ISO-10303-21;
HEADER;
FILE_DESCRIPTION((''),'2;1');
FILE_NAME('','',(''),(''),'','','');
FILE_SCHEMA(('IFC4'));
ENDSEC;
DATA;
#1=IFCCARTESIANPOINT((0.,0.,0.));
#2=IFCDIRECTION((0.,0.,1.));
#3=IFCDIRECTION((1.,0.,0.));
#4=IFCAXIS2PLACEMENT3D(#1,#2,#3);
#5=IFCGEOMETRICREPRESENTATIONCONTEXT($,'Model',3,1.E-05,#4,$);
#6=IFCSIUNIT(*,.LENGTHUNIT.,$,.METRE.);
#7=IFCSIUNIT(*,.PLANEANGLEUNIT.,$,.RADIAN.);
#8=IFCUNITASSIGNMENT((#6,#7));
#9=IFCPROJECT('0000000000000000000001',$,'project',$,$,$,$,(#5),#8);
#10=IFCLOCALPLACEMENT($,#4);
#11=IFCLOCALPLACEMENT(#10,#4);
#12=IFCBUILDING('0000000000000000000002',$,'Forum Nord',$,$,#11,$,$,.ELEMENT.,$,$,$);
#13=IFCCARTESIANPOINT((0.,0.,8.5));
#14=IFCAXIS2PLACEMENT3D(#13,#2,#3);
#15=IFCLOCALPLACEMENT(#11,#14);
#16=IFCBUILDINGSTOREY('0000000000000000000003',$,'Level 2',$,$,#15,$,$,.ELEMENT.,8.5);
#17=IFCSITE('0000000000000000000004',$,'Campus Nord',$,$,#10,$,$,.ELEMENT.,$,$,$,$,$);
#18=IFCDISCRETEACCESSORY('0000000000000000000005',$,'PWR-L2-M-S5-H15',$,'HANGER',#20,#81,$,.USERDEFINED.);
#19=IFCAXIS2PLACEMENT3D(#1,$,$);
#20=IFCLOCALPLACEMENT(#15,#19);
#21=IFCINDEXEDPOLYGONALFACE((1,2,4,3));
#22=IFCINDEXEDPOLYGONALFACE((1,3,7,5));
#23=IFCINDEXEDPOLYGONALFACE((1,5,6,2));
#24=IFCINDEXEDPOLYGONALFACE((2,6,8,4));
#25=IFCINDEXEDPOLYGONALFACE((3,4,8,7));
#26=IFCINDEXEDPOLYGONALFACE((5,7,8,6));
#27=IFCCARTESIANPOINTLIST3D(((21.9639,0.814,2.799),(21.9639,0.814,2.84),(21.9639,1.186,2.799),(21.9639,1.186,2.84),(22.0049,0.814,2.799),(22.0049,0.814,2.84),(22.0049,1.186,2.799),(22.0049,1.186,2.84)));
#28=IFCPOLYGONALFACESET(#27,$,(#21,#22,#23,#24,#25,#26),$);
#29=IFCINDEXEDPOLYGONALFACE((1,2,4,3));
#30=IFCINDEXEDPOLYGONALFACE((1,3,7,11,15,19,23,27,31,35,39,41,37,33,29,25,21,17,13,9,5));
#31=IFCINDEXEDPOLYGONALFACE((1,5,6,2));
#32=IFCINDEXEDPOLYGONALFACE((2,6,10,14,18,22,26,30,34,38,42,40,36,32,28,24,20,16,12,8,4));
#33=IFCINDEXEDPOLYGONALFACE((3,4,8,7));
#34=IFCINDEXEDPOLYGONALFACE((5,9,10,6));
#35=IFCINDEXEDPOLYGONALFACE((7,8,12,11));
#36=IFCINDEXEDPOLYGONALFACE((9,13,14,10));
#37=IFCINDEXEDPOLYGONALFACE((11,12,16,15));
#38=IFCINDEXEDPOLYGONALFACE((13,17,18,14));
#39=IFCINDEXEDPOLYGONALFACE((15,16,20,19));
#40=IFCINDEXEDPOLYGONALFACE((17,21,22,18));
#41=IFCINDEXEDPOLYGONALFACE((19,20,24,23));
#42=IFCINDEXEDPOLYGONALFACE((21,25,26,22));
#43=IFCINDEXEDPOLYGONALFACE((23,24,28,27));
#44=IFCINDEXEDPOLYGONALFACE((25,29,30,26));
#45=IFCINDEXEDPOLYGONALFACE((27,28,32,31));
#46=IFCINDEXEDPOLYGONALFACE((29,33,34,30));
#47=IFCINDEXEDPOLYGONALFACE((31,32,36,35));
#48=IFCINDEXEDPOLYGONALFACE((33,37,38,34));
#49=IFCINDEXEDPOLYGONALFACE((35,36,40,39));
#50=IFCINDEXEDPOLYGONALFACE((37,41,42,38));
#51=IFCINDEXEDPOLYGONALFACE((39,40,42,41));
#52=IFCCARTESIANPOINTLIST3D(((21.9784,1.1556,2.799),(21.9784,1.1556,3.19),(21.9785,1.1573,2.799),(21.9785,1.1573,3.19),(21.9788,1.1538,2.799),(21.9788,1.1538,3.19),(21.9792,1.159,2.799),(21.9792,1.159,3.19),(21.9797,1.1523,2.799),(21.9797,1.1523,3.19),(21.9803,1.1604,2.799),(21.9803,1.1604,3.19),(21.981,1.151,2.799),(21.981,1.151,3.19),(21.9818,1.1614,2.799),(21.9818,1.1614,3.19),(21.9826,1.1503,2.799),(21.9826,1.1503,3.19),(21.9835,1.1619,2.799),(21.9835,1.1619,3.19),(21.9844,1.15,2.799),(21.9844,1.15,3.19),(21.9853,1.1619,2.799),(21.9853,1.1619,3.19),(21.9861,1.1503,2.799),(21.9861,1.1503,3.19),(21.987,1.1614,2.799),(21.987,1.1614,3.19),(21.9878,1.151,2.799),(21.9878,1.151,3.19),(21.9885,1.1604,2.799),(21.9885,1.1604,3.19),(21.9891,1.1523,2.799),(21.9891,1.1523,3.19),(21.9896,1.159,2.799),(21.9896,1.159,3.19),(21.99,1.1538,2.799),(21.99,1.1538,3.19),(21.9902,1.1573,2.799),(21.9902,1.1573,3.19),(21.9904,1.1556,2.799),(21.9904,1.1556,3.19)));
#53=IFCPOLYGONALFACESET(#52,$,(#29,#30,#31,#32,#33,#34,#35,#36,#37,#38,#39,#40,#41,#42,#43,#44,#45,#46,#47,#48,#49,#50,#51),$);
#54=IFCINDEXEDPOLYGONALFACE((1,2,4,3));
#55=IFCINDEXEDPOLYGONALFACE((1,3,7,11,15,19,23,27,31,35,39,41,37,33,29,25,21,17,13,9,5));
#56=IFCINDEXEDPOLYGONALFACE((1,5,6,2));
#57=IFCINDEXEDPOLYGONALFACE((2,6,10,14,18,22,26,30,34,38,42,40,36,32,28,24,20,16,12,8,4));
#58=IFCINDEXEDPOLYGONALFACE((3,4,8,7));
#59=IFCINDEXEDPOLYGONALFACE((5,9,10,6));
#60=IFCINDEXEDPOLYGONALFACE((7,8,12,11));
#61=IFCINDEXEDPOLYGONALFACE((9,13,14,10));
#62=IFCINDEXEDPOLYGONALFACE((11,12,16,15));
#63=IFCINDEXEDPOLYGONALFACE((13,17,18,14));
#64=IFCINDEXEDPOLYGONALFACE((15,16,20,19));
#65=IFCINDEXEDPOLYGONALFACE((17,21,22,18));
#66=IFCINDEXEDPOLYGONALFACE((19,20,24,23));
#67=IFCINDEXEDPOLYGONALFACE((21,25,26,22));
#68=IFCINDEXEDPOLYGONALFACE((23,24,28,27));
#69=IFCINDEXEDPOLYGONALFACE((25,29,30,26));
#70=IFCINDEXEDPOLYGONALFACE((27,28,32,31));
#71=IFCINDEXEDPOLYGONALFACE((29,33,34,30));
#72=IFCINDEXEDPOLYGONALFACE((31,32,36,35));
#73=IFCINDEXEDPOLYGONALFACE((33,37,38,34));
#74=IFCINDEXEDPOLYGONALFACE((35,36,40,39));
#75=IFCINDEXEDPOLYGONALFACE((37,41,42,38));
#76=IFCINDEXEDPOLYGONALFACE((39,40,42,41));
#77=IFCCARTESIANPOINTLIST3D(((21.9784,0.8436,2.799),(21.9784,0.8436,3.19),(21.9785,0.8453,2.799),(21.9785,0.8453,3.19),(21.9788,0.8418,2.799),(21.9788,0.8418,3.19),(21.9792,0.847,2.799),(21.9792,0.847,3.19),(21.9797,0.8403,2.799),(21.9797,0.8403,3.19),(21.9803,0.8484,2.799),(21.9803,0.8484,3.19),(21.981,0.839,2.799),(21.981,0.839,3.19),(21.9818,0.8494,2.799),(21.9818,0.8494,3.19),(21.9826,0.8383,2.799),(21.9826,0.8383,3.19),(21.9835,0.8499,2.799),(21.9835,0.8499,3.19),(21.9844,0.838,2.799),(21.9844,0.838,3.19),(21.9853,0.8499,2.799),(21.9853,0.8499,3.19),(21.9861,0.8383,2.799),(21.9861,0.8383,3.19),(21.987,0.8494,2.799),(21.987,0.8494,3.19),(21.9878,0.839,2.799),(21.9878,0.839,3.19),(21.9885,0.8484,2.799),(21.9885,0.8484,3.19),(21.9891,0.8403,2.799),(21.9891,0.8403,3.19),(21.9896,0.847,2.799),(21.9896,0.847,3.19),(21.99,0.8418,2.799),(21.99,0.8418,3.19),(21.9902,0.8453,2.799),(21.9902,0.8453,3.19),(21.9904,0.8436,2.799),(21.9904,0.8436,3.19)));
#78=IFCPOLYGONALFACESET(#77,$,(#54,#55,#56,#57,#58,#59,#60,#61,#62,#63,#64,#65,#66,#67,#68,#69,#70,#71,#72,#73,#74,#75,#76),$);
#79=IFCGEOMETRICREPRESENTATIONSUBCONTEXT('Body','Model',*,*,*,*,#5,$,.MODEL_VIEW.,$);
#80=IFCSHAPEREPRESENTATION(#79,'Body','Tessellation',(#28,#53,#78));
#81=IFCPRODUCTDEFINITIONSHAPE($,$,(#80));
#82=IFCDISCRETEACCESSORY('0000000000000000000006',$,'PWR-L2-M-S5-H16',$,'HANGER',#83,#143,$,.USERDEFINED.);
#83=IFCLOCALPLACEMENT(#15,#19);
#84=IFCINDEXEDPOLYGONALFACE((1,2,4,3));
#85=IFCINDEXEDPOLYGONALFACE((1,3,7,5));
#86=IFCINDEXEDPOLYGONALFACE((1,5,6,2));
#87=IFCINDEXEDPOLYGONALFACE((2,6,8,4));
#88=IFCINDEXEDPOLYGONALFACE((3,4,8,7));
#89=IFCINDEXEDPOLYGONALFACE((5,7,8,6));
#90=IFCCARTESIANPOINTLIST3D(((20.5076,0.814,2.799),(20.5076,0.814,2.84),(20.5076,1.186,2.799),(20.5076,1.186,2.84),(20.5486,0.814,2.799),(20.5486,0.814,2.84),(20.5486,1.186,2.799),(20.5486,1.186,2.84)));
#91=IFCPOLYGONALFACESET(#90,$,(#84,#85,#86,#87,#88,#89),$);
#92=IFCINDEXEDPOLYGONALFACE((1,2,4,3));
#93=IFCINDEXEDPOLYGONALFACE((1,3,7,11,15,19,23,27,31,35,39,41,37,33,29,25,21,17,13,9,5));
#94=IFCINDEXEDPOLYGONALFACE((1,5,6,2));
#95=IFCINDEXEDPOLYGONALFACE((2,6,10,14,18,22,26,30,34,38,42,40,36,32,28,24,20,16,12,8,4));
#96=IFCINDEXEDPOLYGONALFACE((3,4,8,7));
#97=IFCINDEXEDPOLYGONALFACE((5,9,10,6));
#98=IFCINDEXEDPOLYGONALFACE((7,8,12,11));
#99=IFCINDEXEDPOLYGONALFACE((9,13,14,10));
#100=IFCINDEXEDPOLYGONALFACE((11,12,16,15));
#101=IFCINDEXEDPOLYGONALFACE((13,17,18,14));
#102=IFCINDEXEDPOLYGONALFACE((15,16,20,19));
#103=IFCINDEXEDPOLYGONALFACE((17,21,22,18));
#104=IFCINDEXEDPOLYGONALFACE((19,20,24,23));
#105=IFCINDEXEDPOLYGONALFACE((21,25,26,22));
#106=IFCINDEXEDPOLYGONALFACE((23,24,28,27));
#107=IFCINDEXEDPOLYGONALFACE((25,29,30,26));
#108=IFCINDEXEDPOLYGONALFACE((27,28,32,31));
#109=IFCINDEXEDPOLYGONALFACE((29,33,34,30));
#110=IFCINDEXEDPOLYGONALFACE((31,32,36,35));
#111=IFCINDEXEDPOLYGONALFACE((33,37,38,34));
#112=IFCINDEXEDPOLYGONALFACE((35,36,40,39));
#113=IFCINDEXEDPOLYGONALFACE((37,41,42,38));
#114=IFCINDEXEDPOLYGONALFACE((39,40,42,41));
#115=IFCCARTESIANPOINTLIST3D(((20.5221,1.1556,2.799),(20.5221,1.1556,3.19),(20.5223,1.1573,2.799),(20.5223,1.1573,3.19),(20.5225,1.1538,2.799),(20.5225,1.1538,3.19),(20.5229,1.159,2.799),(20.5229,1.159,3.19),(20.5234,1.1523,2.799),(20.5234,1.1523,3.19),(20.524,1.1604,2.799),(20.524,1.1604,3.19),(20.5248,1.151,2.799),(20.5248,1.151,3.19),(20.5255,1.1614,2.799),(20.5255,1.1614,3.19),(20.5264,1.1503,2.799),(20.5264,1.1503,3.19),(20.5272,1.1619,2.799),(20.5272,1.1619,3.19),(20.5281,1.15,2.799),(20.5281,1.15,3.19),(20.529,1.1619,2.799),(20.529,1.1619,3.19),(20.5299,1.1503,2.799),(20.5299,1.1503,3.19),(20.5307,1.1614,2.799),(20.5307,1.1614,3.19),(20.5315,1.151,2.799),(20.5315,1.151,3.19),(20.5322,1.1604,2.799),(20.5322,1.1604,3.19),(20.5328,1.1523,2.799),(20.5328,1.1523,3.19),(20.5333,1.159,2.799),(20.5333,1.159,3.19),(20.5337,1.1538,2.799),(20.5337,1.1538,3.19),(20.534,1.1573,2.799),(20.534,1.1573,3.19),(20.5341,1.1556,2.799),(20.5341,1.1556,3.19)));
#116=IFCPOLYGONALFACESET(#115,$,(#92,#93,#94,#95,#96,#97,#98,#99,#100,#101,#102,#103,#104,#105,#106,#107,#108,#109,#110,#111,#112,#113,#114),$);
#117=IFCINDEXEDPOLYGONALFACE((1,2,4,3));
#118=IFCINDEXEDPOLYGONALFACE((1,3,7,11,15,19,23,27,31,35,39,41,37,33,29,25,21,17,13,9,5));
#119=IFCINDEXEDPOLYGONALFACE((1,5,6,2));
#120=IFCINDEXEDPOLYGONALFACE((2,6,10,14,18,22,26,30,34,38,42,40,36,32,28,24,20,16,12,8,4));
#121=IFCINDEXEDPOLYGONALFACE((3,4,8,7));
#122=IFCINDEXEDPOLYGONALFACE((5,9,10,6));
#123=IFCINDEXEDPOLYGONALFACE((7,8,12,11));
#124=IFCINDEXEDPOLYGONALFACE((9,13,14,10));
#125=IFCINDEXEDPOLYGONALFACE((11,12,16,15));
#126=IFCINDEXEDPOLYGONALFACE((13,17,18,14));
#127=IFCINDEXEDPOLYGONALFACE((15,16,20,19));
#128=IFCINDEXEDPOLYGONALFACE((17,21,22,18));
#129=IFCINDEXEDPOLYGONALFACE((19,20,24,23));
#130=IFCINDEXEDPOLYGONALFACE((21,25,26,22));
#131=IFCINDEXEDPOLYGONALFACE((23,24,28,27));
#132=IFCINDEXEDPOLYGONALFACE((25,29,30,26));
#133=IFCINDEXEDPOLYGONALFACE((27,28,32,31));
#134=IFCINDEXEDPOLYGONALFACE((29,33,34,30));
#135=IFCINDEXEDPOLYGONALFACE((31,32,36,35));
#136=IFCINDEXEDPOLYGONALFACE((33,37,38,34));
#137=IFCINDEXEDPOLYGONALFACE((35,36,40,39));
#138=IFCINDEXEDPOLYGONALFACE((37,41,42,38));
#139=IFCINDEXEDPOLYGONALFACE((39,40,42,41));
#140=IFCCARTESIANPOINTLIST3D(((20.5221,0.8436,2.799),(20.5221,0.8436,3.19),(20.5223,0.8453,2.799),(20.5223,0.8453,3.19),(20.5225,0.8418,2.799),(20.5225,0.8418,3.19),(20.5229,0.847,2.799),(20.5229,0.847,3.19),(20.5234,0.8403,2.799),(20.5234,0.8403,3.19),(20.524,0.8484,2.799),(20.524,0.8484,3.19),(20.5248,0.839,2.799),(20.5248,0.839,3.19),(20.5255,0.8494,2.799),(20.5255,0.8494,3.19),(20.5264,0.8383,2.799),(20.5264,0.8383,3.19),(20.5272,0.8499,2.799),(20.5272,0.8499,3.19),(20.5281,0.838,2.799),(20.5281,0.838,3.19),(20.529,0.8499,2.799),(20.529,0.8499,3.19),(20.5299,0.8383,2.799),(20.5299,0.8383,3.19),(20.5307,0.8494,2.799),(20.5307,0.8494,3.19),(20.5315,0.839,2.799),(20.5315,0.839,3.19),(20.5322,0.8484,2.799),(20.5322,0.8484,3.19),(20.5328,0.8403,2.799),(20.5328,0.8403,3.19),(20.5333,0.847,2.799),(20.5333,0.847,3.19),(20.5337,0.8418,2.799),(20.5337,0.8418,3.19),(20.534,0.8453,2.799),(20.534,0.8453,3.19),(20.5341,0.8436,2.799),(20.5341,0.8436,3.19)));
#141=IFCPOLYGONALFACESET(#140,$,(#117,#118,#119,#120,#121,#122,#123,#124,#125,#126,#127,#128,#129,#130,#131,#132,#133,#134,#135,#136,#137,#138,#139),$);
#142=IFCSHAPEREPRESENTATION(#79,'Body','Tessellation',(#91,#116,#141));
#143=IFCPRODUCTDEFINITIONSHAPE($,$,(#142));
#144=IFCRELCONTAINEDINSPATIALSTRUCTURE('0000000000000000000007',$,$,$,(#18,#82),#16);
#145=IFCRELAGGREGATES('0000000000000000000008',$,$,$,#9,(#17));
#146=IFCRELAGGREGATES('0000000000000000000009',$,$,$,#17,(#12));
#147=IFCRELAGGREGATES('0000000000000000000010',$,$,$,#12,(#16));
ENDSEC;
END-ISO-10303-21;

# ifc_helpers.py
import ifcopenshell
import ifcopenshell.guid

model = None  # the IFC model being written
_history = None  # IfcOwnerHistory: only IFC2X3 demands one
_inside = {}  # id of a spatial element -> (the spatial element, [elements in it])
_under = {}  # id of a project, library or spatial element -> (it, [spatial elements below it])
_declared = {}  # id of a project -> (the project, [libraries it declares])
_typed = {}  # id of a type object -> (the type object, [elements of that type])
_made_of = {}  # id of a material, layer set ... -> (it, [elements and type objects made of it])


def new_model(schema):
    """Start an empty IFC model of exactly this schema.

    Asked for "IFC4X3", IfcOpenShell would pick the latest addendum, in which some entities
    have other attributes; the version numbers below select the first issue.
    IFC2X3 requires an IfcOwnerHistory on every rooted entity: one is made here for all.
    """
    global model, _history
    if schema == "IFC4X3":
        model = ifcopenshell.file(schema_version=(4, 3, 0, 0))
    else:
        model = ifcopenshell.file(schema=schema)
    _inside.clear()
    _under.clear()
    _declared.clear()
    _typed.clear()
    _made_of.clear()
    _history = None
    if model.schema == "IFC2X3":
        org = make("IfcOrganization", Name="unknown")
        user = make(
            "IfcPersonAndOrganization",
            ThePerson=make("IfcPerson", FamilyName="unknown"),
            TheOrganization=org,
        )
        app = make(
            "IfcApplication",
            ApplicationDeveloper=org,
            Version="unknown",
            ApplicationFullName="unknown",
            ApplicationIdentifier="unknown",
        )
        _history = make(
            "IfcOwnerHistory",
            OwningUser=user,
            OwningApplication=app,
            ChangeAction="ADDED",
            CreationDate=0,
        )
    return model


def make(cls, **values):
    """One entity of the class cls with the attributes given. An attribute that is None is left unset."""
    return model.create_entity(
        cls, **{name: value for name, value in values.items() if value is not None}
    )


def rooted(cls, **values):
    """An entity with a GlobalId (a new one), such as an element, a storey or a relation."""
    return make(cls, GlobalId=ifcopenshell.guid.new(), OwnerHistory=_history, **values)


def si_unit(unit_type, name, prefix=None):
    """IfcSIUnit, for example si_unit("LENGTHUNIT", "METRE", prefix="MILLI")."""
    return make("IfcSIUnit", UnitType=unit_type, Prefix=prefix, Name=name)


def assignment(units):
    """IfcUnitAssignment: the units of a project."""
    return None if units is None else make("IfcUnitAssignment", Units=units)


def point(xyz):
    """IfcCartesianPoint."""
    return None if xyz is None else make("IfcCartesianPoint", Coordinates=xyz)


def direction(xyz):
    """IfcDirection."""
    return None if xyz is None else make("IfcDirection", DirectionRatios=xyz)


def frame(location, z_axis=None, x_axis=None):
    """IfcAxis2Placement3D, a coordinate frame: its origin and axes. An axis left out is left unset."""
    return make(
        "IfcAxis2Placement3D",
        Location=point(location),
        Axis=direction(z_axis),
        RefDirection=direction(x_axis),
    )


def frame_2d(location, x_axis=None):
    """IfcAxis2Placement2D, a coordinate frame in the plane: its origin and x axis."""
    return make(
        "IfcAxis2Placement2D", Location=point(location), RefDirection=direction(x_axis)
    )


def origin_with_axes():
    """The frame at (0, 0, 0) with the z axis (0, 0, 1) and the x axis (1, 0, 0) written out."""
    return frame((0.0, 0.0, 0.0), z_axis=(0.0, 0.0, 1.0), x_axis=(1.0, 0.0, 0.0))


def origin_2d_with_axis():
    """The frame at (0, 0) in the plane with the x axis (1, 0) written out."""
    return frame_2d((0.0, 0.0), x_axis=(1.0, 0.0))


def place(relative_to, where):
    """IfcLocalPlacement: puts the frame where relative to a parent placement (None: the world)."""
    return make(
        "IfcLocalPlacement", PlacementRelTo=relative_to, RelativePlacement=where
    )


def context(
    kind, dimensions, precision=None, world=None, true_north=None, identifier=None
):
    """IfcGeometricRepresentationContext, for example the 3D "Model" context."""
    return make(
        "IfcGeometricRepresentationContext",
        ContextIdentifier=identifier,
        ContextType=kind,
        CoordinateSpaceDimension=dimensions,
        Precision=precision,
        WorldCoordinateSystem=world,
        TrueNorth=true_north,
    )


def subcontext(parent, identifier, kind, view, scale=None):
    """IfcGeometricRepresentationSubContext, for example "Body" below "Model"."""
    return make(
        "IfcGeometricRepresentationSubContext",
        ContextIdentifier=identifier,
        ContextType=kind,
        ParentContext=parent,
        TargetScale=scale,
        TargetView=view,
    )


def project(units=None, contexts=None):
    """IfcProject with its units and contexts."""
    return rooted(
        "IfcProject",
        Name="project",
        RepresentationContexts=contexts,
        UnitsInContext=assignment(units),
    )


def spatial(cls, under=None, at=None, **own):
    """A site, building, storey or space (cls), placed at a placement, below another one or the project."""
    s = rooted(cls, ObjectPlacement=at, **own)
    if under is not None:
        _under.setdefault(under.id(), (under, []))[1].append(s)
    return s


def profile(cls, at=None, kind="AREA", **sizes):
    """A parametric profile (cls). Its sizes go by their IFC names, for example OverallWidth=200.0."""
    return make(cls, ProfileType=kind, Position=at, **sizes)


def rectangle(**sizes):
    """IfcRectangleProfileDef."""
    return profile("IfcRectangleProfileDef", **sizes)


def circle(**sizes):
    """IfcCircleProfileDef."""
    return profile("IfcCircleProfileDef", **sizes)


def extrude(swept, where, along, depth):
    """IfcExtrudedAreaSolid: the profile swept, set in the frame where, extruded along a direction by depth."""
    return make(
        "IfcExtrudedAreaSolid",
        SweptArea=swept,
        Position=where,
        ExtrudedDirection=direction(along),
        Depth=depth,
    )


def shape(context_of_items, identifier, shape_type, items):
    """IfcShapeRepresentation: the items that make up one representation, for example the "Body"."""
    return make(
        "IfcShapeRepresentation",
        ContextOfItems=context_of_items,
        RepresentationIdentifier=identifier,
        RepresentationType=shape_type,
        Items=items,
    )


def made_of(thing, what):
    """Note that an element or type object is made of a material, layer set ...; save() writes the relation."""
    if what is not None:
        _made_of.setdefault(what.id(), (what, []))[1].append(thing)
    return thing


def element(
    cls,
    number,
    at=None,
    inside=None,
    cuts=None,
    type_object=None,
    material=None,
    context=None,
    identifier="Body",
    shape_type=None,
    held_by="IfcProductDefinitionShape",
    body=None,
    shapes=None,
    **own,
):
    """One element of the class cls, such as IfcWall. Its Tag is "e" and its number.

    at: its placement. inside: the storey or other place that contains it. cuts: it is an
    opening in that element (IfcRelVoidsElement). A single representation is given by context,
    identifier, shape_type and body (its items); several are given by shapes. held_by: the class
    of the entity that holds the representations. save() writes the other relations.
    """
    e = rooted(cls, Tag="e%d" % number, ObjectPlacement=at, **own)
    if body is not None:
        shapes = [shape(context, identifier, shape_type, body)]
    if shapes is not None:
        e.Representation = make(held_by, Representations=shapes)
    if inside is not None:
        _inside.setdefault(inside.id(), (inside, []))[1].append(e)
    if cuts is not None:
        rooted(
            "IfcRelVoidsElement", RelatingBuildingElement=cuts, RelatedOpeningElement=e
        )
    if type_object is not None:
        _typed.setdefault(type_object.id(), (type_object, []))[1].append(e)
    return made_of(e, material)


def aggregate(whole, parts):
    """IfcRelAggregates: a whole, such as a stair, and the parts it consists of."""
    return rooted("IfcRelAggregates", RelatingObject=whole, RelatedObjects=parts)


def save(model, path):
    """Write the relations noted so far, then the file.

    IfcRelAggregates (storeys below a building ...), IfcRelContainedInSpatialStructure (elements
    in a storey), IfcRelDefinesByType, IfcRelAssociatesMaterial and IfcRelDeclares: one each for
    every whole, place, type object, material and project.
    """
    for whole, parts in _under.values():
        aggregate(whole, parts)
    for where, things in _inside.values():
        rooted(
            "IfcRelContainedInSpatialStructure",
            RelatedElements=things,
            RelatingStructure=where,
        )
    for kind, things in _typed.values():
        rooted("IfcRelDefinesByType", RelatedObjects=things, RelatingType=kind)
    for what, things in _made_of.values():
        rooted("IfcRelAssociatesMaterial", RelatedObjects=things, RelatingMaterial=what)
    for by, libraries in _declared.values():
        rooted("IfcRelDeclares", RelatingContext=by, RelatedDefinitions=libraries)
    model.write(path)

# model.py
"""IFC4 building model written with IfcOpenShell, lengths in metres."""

from ifc_helpers import new_model, si_unit, frame, frame_2d, origin_with_axes, origin_2d_with_axis, place, context, subcontext, project, spatial, rectangle, circle, extrude, element, save


model = new_model("IFC4")

# Units and contexts
model_context = context("Model", 3, precision=1e-05, world=origin_with_axes())
body_context = subcontext(model_context, "Body", "Model", "MODEL_VIEW")
ifc_project = project(units=[si_unit("LENGTHUNIT", "METRE"), si_unit("PLANEANGLEUNIT", "RADIAN")], contexts=[model_context])

# Site, building, storey
site_placement = place(None, origin_with_axes())
site = spatial("IfcSite", under=ifc_project, at=site_placement, Name="Campus Nord", CompositionType="ELEMENT")
building_placement = place(site_placement, origin_with_axes())
building = spatial("IfcBuilding", under=site, at=building_placement, Name="Forum Nord", CompositionType="ELEMENT")
storey_placement = place(building_placement, frame((0.0, 0.0, 8.5), z_axis=(0.0, 0.0, 1.0), x_axis=(1.0, 0.0, 0.0)))
storey = spatial("IfcBuildingStorey", under=building, at=storey_placement, Name="Level 2", CompositionType="ELEMENT", Elevation=8.5)

# Discrete accessories
for number, where, z_axis, x_axis, name in (
    (1, (21.9844, 1.0, 2.84), (0.0, 0.0, 1.0), (0.0, -1.0, 0.0), "PWR-L2-M-S5-H15"),
    (2, (20.5281, 1.0, 2.84), (0.0, 0.0, 1.0), (0.0, -1.0, 0.0), "PWR-L2-M-S5-H16"),
):
    element("IfcDiscreteAccessory", number, at=place(storey_placement, frame(where, z_axis=z_axis, x_axis=x_axis)), inside=storey, Name=name, ObjectType="HANGER", PredefinedType="USERDEFINED", context=body_context, shape_type="SweptSolid", body=[
        extrude(rectangle(XDim=0.372, YDim=0.041, at=origin_2d_with_axis()), frame((0.0, 0.0, -0.041), z_axis=(0.0, 0.0, 1.0), x_axis=(1.0, 0.0, 0.0)), (0.0, 0.0, 1.0), 0.041),
        extrude(circle(Radius=0.006, at=frame_2d((-0.156, 0.0), x_axis=(1.0, 0.0))), frame((0.0, 0.0, -0.041), z_axis=(0.0, 0.0, 1.0), x_axis=(1.0, 0.0, 0.0)), (0.0, 0.0, 1.0), 0.391),
        extrude(circle(Radius=0.006, at=frame_2d((0.156, 0.0), x_axis=(1.0, 0.0))), frame((0.0, 0.0, -0.041), z_axis=(0.0, 0.0, 1.0), x_axis=(1.0, 0.0, 0.0)), (0.0, 0.0, 1.0), 0.391),
    ])

save(model, "model.ifc")
